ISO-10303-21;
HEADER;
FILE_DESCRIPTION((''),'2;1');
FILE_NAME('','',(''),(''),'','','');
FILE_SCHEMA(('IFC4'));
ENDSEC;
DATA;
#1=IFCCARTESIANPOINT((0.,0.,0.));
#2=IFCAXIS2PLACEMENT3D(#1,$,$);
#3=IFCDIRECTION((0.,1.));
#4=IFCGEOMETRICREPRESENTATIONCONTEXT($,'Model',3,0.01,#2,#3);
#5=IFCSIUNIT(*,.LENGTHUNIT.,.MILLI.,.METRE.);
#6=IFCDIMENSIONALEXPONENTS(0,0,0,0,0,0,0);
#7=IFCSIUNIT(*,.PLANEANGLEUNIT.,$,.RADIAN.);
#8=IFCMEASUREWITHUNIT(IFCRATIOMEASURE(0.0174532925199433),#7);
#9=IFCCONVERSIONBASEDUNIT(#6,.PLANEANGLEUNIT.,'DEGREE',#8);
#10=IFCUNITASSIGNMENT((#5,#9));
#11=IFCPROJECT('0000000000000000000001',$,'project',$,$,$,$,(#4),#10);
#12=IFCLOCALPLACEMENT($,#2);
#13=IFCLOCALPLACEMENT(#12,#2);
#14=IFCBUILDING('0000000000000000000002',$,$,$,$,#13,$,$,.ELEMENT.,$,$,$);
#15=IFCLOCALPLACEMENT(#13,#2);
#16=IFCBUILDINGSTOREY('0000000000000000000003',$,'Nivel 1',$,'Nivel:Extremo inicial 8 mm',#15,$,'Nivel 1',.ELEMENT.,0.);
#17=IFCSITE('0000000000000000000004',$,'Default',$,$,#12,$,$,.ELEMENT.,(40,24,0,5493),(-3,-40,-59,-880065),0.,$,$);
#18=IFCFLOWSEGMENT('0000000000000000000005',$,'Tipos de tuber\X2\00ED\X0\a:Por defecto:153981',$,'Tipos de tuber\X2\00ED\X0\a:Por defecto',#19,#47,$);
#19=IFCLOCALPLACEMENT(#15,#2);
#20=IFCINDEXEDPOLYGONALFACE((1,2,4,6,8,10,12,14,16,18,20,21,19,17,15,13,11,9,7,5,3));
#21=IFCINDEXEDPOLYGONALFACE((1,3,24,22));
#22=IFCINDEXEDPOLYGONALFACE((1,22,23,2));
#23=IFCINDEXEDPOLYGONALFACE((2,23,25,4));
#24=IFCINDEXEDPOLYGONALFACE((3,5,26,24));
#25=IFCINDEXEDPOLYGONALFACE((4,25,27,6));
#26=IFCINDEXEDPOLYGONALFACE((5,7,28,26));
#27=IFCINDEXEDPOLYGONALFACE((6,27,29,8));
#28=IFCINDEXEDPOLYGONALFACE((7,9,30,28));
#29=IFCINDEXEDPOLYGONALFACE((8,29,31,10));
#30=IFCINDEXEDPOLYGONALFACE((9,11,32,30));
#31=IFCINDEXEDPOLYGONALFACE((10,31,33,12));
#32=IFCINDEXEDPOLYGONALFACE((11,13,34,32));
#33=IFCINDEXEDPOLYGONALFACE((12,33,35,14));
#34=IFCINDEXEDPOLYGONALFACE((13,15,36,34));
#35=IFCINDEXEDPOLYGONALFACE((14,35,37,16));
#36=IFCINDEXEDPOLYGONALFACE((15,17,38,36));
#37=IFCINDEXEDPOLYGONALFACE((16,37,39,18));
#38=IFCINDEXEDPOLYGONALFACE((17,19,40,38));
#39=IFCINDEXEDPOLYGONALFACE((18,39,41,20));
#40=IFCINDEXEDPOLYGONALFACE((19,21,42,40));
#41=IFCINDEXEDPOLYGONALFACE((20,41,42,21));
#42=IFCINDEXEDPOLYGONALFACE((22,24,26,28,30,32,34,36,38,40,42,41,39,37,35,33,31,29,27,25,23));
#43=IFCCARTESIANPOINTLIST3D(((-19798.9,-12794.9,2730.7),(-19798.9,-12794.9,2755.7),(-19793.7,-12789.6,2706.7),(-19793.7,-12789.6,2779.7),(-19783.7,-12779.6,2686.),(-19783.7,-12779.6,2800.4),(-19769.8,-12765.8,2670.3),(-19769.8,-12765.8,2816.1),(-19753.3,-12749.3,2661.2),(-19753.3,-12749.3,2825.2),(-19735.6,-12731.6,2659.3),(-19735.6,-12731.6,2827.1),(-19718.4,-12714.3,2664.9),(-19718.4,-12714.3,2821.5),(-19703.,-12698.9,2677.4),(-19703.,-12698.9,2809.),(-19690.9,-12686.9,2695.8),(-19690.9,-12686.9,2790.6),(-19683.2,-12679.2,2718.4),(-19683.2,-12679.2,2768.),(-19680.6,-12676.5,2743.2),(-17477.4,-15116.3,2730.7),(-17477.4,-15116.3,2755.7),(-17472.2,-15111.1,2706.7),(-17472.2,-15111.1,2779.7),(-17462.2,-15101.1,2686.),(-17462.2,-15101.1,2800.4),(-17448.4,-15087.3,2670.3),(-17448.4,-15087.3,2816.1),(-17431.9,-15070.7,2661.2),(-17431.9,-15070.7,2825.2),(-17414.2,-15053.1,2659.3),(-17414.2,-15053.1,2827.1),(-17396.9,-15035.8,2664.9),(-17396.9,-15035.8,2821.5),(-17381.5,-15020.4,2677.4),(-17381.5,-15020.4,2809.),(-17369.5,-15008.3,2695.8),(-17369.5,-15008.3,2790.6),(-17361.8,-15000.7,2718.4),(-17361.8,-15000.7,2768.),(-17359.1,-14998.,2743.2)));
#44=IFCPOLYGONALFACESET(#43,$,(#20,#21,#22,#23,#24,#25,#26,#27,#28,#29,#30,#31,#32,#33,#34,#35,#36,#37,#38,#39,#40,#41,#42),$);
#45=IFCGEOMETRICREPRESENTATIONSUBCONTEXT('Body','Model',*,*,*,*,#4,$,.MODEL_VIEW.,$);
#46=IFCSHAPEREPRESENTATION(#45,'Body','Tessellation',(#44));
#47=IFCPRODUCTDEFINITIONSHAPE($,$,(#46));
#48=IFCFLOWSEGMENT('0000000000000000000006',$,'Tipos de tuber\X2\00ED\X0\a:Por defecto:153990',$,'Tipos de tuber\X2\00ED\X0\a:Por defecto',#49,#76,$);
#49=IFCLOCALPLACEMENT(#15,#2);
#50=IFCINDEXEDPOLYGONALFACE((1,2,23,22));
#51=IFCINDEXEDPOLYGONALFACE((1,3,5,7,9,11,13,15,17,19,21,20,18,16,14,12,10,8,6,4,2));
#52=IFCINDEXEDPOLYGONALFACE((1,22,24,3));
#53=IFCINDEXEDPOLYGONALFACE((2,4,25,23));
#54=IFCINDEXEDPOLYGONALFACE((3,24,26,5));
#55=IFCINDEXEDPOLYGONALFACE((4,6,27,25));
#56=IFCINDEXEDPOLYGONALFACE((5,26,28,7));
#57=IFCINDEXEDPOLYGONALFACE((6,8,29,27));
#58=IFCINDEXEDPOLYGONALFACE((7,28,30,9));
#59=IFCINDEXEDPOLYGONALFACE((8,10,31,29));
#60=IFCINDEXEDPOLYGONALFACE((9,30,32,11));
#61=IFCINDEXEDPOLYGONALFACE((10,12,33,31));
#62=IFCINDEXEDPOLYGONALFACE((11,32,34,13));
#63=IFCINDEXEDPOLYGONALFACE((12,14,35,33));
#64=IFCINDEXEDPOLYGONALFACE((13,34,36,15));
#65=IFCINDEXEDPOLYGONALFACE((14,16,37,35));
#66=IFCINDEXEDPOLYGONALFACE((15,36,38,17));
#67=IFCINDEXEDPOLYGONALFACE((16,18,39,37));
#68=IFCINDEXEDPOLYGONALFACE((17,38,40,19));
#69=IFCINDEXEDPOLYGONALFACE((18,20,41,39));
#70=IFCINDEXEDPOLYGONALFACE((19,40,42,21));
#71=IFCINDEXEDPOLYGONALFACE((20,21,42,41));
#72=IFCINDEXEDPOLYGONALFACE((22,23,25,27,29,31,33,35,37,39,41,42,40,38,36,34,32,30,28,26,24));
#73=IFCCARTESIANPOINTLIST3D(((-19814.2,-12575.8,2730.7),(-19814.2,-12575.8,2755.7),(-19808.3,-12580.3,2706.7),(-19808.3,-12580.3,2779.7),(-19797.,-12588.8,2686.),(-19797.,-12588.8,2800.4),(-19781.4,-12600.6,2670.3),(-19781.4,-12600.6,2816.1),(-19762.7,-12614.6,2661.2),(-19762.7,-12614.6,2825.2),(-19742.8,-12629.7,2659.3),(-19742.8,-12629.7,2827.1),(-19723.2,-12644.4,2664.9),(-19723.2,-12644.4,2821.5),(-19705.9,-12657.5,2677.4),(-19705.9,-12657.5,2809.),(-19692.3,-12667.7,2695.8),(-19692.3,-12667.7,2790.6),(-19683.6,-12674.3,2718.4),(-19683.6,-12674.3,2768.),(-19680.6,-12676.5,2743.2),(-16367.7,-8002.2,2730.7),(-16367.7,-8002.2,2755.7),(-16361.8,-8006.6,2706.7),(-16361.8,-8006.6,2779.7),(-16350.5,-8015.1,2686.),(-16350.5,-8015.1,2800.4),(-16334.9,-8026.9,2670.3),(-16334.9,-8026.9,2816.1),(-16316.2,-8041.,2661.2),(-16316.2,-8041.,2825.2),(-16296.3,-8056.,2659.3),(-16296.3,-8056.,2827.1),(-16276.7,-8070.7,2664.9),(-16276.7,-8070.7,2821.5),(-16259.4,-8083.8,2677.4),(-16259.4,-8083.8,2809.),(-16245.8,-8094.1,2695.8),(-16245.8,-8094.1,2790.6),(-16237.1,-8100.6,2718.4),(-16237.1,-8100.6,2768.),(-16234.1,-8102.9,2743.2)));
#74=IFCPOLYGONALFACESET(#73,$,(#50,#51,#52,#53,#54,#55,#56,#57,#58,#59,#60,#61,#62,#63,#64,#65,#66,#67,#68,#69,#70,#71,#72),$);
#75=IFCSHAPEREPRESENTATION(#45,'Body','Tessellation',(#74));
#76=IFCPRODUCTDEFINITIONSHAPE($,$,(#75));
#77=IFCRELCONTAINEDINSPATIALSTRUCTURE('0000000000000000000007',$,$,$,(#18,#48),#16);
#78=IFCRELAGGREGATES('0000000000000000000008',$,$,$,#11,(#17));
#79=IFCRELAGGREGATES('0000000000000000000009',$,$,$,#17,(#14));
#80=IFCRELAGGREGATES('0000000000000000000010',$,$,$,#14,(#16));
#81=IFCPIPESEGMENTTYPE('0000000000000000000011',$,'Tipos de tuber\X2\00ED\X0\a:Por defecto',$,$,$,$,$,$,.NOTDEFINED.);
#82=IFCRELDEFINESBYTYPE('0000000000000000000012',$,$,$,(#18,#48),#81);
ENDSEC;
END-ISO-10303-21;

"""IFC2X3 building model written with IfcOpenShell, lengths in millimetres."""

from ifc_helpers import new_model, entity, si_unit, converted_unit, direction, frame, frame_2d, origin, origin_2d_with_axis, place, context, subcontext, project, spatial, circle, extrude, type_object, element, save


model = new_model("IFC2X3")

# Units and contexts
model_context = context("Model", 3, precision=0.01, world=origin(), true_north=direction((0.0, 1.0)))
body_context = subcontext(model_context, "Body", "Model", "MODEL_VIEW")
ifc_project = project(units=[si_unit("LENGTHUNIT", "METRE", prefix="MILLI"), converted_unit("PLANEANGLEUNIT", "DEGREE", entity("IfcRatioMeasure", 0.0174532925199433), si_unit("PLANEANGLEUNIT", "RADIAN"), dimensions=[0, 0, 0, 0, 0, 0, 0])], contexts=[model_context])

# Site, building, storey
site_placement = place(None, origin())
site = spatial("IfcSite", under=ifc_project, at=site_placement, Name="Default", CompositionType="ELEMENT", RefLatitude=(40, 24, 0, 5493), RefLongitude=(-3, -40, -59, -880065), RefElevation=0.0)
building_placement = place(site_placement, origin())
building = spatial("IfcBuilding", under=site, at=building_placement, CompositionType="ELEMENT")
storey_placement = place(building_placement, origin())
storey = spatial("IfcBuildingStorey", under=building, at=storey_placement, Name="Nivel 1", ObjectType="Nivel:Extremo inicial 8 mm", LongName="Nivel 1", CompositionType="ELEMENT", Elevation=0.0)

# Flow segments
pipe_segment_type = type_object("IfcPipeSegmentType", Name="Tipos de tubería:Por defecto", PredefinedType="NOTDEFINED")
flow_segment_1_placement = place(storey_placement, origin())
element("IfcFlowSegment", 1, at=flow_segment_1_placement, inside=storey, type_object=pipe_segment_type, Name="Tipos de tubería:Por defecto:153981", ObjectType="Tipos de tubería:Por defecto", context=body_context, shape_type="SweptSolid", body=[
    extrude(circle(Radius=84.1, at=frame_2d((0.0, 0.0), x_axis=(1.0, 0.0))), frame((-17418.6, -15057.5, 2743.2), z_axis=(-0.707107, 0.707107, 0.0), x_axis=(0.707107, 0.707107, 0.0)), (0.0, 0.0, 1.0), 3283.1),
])
flow_segment_2_placement = place(storey_placement, origin())
element("IfcFlowSegment", 2, at=flow_segment_2_placement, inside=storey, type_object=pipe_segment_type, Name="Tipos de tubería:Por defecto:153990", ObjectType="Tipos de tubería:Por defecto", context=body_context, shape_type="SweptSolid", body=[
    extrude(circle(Radius=84.1, at=origin_2d_with_axis()), frame((-19747.8, -12625.9, 2743.2), z_axis=(0.601815, 0.798636, 0.0), x_axis=(0.798636, -0.601815, 0.0)), (0.0, 0.0, 1.0), 5726.9),
])

save(model, "model.ifc")
